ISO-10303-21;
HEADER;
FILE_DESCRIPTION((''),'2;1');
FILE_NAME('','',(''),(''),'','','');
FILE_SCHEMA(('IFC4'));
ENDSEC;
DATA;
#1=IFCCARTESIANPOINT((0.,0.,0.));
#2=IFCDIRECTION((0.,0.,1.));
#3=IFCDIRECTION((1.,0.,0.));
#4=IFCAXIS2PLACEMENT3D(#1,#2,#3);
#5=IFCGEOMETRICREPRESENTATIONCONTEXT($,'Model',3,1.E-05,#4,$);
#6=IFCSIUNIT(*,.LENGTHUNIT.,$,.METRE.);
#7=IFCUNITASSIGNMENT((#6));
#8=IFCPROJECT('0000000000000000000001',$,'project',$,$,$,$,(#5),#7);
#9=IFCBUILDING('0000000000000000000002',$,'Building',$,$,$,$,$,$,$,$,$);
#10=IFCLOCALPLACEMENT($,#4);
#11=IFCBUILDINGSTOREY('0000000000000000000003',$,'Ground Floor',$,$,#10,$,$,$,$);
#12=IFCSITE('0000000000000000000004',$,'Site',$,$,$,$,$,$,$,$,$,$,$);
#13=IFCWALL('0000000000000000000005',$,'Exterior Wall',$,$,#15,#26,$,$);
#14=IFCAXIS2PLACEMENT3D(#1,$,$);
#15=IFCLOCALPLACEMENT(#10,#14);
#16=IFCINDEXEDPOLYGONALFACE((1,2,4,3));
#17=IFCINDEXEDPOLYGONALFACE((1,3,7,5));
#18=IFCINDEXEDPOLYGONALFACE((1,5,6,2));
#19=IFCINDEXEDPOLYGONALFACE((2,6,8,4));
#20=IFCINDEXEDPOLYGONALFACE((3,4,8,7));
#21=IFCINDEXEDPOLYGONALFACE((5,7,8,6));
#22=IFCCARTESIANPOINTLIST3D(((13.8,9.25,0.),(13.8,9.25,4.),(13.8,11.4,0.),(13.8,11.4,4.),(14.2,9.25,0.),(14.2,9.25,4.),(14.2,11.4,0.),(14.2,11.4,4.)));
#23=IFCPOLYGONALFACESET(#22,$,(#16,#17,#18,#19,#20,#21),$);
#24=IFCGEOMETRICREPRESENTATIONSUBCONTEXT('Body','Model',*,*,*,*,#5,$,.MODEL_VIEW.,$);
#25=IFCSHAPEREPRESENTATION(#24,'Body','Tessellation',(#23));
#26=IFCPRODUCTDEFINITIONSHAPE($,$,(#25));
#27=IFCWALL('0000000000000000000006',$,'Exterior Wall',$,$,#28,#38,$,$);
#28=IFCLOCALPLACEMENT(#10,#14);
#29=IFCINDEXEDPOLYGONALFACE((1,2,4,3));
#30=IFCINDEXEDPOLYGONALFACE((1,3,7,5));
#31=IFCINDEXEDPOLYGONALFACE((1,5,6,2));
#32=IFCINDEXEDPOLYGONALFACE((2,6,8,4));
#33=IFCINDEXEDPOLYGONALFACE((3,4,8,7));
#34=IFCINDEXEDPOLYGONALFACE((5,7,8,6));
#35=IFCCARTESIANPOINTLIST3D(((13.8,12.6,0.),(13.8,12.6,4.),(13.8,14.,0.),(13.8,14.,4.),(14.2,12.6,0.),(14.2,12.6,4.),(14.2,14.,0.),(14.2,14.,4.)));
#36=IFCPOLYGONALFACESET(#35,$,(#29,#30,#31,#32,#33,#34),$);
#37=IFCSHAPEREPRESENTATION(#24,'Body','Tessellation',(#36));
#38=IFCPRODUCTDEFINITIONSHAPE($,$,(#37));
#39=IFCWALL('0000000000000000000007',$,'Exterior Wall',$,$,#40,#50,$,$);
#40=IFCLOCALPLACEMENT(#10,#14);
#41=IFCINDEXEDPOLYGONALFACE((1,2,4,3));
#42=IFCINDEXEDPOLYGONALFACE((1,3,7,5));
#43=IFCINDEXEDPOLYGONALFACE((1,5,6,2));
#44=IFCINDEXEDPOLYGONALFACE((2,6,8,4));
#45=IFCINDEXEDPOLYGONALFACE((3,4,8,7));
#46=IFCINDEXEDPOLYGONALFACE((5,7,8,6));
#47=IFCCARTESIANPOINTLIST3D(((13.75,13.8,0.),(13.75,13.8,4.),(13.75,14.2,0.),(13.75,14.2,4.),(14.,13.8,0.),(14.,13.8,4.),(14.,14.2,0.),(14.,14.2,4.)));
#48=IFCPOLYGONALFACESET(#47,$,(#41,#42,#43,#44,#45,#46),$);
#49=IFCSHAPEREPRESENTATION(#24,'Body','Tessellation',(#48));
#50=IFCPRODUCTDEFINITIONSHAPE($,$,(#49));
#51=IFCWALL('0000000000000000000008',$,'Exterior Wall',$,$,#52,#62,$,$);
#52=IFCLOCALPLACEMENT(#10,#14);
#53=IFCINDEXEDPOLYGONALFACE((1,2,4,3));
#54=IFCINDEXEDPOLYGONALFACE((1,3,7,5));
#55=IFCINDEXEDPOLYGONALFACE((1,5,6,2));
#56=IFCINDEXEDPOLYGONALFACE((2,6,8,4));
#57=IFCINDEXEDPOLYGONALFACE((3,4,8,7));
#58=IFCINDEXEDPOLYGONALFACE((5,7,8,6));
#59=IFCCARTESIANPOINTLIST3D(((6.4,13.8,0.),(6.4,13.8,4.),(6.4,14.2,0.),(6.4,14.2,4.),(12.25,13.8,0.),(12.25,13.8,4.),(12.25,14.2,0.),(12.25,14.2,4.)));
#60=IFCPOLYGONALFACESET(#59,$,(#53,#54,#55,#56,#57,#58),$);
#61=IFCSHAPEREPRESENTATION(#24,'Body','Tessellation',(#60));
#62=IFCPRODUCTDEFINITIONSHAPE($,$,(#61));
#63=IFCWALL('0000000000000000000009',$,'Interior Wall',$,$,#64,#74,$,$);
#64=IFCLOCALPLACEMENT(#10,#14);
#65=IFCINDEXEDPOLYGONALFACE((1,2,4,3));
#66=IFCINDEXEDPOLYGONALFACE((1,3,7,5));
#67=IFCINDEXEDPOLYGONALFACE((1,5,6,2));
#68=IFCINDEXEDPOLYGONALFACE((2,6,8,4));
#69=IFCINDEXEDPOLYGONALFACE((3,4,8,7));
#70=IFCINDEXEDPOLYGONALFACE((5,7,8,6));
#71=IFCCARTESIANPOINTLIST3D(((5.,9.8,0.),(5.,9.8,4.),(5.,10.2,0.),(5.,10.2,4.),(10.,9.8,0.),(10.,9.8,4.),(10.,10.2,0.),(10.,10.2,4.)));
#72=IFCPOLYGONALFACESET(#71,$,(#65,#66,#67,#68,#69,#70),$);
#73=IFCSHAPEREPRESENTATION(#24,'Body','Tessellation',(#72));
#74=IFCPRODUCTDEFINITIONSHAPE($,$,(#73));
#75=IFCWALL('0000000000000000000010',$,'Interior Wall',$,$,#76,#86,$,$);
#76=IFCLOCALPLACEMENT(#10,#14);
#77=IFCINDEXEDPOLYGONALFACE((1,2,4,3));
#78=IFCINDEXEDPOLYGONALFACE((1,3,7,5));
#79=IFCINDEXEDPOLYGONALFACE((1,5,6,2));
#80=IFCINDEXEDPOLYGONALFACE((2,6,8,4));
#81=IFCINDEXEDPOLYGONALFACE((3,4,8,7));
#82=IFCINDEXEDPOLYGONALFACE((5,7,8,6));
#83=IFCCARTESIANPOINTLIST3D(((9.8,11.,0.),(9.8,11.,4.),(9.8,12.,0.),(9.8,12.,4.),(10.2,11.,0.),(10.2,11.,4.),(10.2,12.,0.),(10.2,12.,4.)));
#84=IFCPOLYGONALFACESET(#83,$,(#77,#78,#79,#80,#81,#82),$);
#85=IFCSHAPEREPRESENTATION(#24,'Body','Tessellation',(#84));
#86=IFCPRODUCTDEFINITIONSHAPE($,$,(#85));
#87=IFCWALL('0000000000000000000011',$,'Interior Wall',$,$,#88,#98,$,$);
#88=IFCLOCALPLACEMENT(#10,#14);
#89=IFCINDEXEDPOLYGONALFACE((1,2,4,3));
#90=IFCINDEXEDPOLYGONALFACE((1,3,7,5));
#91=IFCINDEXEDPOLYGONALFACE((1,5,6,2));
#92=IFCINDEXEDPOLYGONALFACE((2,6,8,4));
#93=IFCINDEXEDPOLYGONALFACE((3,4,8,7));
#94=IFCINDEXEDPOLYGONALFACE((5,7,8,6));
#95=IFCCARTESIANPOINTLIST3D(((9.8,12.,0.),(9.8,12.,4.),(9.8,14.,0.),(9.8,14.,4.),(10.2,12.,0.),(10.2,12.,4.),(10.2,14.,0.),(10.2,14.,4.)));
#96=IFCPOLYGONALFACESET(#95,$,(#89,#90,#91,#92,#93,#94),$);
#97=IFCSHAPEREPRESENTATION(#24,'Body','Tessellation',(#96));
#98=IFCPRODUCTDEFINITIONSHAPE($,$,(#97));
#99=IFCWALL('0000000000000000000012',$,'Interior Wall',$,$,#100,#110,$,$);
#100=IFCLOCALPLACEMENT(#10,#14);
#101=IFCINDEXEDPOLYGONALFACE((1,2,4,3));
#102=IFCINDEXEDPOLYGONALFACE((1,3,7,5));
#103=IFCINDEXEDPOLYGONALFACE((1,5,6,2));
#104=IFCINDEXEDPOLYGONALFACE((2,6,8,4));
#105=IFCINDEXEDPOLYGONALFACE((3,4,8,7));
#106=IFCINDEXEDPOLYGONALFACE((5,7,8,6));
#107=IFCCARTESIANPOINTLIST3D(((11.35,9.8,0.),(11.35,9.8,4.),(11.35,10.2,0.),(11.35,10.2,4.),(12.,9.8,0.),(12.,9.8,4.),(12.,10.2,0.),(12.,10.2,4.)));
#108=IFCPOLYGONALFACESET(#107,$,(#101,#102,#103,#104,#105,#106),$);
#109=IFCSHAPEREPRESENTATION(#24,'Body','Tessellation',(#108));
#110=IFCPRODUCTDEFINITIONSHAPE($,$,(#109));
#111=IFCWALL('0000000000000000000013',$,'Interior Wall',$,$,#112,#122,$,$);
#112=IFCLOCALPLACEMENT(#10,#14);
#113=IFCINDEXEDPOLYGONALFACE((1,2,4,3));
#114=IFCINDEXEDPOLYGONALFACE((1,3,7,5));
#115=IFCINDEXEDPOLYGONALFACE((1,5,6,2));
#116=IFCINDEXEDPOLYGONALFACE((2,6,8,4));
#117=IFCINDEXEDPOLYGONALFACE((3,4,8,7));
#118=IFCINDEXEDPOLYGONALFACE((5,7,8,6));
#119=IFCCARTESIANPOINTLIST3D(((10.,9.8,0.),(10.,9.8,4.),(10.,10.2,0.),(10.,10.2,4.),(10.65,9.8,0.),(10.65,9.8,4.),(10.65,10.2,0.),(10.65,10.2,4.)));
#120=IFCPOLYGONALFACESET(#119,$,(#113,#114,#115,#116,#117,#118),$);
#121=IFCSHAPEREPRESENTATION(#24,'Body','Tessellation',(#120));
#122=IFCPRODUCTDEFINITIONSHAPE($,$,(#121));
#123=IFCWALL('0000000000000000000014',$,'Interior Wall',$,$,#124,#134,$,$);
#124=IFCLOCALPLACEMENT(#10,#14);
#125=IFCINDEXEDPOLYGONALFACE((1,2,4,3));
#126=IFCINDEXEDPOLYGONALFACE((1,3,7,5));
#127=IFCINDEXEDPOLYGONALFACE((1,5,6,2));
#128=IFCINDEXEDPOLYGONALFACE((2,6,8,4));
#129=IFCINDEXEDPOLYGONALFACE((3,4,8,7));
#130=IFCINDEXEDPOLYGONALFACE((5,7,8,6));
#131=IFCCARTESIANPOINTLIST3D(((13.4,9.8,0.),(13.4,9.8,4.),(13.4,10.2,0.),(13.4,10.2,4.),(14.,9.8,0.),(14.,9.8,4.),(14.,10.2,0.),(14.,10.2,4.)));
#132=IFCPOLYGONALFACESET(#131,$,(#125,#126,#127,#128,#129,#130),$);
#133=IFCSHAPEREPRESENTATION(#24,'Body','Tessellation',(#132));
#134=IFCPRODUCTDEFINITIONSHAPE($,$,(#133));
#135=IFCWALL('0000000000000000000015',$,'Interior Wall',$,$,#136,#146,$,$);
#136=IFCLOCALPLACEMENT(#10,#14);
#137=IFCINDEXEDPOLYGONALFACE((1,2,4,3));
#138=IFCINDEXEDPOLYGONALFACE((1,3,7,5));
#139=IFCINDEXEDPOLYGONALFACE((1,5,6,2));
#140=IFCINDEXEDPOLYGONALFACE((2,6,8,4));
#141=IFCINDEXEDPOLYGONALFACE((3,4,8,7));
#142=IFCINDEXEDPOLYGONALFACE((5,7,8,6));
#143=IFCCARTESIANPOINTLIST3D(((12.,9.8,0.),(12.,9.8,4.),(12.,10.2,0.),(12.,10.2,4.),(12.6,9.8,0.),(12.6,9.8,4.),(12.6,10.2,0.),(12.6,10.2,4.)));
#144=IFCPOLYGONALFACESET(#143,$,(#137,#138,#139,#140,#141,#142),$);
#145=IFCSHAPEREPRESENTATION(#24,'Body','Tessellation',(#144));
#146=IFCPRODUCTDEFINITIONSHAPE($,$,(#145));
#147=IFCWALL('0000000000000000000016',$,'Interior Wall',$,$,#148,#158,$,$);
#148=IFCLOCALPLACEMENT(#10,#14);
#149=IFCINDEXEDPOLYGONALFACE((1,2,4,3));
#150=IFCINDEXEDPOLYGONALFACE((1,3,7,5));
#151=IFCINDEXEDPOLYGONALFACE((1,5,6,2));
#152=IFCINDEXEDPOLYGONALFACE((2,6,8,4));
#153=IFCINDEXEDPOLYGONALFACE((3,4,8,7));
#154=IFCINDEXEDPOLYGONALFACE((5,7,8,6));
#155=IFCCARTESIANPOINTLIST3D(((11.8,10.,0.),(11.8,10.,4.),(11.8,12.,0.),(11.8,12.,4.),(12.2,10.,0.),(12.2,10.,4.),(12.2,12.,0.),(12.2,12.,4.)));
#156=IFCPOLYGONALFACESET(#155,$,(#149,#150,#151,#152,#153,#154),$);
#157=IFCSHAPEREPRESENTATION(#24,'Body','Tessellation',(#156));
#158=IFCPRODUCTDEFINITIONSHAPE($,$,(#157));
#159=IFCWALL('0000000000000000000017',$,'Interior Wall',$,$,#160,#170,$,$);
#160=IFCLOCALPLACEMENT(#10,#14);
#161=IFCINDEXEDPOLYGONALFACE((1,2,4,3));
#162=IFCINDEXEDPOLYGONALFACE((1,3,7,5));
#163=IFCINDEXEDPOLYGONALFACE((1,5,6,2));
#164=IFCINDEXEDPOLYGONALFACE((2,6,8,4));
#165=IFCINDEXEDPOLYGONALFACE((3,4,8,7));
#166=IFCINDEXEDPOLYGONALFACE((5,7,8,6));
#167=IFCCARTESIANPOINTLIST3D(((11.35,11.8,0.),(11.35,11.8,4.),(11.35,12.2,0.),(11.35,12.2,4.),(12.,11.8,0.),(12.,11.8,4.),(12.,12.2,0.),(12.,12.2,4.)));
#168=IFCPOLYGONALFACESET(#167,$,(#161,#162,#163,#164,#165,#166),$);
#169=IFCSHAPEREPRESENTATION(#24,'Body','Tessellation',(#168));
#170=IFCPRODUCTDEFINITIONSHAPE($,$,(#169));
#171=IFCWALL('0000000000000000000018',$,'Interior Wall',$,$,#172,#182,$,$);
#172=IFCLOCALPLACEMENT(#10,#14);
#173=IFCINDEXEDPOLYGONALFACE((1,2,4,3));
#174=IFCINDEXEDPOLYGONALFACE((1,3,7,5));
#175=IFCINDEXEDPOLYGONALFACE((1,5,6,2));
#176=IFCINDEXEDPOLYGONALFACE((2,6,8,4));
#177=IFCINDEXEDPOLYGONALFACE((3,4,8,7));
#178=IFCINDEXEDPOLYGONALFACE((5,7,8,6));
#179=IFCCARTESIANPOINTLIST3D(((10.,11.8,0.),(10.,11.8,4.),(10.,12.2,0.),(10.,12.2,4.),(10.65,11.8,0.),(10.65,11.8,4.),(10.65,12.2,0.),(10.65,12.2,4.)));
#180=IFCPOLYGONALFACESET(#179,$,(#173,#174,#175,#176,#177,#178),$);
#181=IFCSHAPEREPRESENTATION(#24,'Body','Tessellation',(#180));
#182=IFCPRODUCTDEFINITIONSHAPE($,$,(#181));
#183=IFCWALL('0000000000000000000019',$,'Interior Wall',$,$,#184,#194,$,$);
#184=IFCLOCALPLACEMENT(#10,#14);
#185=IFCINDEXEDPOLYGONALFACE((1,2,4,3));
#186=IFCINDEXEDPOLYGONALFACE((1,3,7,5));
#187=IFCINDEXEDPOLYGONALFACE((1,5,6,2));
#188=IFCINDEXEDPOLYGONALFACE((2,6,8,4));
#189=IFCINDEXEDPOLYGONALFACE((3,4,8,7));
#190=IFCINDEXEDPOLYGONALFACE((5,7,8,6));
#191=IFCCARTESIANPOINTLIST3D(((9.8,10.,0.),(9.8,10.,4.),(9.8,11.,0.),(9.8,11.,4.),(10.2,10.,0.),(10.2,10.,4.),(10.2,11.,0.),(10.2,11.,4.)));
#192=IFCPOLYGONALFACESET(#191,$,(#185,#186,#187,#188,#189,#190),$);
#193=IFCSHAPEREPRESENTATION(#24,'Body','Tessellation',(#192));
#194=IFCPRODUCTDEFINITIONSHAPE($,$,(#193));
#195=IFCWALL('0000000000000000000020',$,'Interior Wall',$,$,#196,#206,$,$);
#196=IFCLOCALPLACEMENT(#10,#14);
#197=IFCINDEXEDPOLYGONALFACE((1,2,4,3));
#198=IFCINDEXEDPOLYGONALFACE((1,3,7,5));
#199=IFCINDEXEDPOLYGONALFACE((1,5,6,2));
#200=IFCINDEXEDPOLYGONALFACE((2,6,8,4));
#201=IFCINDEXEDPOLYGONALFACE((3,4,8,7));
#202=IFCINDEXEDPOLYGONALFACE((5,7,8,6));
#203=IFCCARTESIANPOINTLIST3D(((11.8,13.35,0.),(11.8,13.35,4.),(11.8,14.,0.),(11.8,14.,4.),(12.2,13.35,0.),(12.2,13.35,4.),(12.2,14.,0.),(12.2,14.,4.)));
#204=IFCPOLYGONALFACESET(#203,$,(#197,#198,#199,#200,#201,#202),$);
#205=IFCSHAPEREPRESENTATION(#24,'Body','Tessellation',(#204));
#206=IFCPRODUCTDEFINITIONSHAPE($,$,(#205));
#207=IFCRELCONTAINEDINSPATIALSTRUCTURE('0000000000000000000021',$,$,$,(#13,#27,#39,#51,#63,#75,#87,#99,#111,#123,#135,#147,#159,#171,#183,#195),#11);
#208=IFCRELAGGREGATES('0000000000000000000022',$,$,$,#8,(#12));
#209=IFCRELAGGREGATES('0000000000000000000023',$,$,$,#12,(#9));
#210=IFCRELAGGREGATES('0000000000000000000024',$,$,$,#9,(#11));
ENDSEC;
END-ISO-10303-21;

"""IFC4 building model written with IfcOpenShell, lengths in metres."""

from ifc_helpers import new_model, si_unit, frame, origin_with_axes, place, context, subcontext, project, spatial, indexed_curve, outline, extrude, element, save


model = new_model("IFC4")

# Units and contexts
model_context = context("Model", 3, precision=1e-05, world=origin_with_axes())
body_context = subcontext(model_context, "Body", "Model", "MODEL_VIEW")
ifc_project = project(units=[si_unit("LENGTHUNIT", "METRE")], contexts=[model_context])

# Site, building, storey
site = spatial("IfcSite", under=ifc_project, Name="Site")
building = spatial("IfcBuilding", under=site, Name="Building")
storey_placement = place(None, origin_with_axes())
storey = spatial("IfcBuildingStorey", under=building, at=storey_placement, Name="Ground Floor")

# Walls
wall_1_placement = place(storey_placement, frame((14.0, 9.25, 0.0), z_axis=(0.0, 0.0, 1.0), x_axis=(0.0, 1.0, 0.0)))
element("IfcWall", 1, at=wall_1_placement, inside=storey, Name="Exterior Wall", context=body_context, shape_type="SweptSolid", body=[
    extrude(outline(indexed_curve([(0.0, 0.0), (0.0, 0.4), (2.15, 0.4), (2.15, 0.0), (0.0, 0.0)], self_intersect=False)), frame((0.0, -0.2, 0.0), z_axis=(0.0, 0.0, 1.0), x_axis=(1.0, 0.0, 0.0)), (0.0, 0.0, 1.0), 4.0),
])
wall_2_placement = place(storey_placement, frame((14.0, 12.6, 0.0), z_axis=(0.0, 0.0, 1.0), x_axis=(0.0, 1.0, 0.0)))
element("IfcWall", 2, at=wall_2_placement, inside=storey, Name="Exterior Wall", context=body_context, shape_type="SweptSolid", body=[
    extrude(outline(indexed_curve([(0.0, 0.0), (0.0, 0.4), (1.4, 0.4), (1.4, 0.0), (0.0, 0.0)], self_intersect=False)), frame((0.0, -0.2, 0.0), z_axis=(0.0, 0.0, 1.0), x_axis=(1.0, 0.0, 0.0)), (0.0, 0.0, 1.0), 4.0),
])
wall_3_placement = place(storey_placement, frame((14.0, 14.0, 0.0), z_axis=(0.0, 0.0, 1.0), x_axis=(-1.0, 0.0, 0.0)))
element("IfcWall", 3, at=wall_3_placement, inside=storey, Name="Exterior Wall", context=body_context, shape_type="SweptSolid", body=[
    extrude(outline(indexed_curve([(0.0, 0.0), (0.0, 0.4), (0.25, 0.4), (0.25, 0.0), (0.0, 0.0)], self_intersect=False)), frame((0.0, -0.2, 0.0), z_axis=(0.0, 0.0, 1.0), x_axis=(1.0, 0.0, 0.0)), (0.0, 0.0, 1.0), 4.0),
])
wall_4_placement = place(storey_placement, frame((12.25, 14.0, 0.0), z_axis=(0.0, 0.0, 1.0), x_axis=(-1.0, 0.0, 0.0)))
element("IfcWall", 4, at=wall_4_placement, inside=storey, Name="Exterior Wall", context=body_context, shape_type="SweptSolid", body=[
    extrude(outline(indexed_curve([(0.0, 0.0), (0.0, 0.4), (5.85, 0.4), (5.85, 0.0), (0.0, 0.0)], self_intersect=False)), frame((0.0, -0.2, 0.0), z_axis=(0.0, 0.0, 1.0), x_axis=(1.0, 0.0, 0.0)), (0.0, 0.0, 1.0), 4.0),
])
wall_5_placement = place(storey_placement, frame((10.0, 10.0, 0.0), z_axis=(0.0, 0.0, 1.0), x_axis=(-1.0, 0.0, 0.0)))
element("IfcWall", 5, at=wall_5_placement, inside=storey, Name="Interior Wall", context=body_context, shape_type="SweptSolid", body=[
    extrude(outline(indexed_curve([(0.0, 0.0), (0.0, 0.4), (5.0, 0.4), (5.0, 0.0), (0.0, 0.0)], self_intersect=False)), frame((0.0, -0.2, 0.0), z_axis=(0.0, 0.0, 1.0), x_axis=(1.0, 0.0, 0.0)), (0.0, 0.0, 1.0), 4.0),
])
wall_6_placement = place(storey_placement, frame((10.0, 11.0, 0.0), z_axis=(0.0, 0.0, 1.0), x_axis=(0.0, 1.0, 0.0)))
element("IfcWall", 6, at=wall_6_placement, inside=storey, Name="Interior Wall", context=body_context, shape_type="SweptSolid", body=[
    extrude(outline(indexed_curve([(0.0, 0.0), (0.0, 0.4), (1.0, 0.4), (1.0, 0.0), (0.0, 0.0)], self_intersect=False)), frame((0.0, -0.2, 0.0), z_axis=(0.0, 0.0, 1.0), x_axis=(1.0, 0.0, 0.0)), (0.0, 0.0, 1.0), 4.0),
])
wall_7_placement = place(storey_placement, frame((10.0, 12.0, 0.0), z_axis=(0.0, 0.0, 1.0), x_axis=(0.0, 1.0, 0.0)))
element("IfcWall", 7, at=wall_7_placement, inside=storey, Name="Interior Wall", context=body_context, shape_type="SweptSolid", body=[
    extrude(outline(indexed_curve([(0.0, 0.0), (0.0, 0.4), (2.0, 0.4), (2.0, 0.0), (0.0, 0.0)], self_intersect=False)), frame((0.0, -0.2, 0.0), z_axis=(0.0, 0.0, 1.0), x_axis=(1.0, 0.0, 0.0)), (0.0, 0.0, 1.0), 4.0),
])
for number, where, z_axis, x_axis, name in (
    (8, (12.0, 10.0, 0.0), (0.0, 0.0, 1.0), (-1.0, 0.0, 0.0), "Interior Wall"),
    (9, (10.65, 10.0, 0.0), (0.0, 0.0, 1.0), (-1.0, 0.0, 0.0), "Interior Wall"),
):
    element("IfcWall", number, at=place(storey_placement, frame(where, z_axis=z_axis, x_axis=x_axis)), inside=storey, Name=name, context=body_context, shape_type="SweptSolid", body=[
        extrude(outline(indexed_curve([(0.0, 0.0), (0.0, 0.4), (0.65, 0.4), (0.65, 0.0), (0.0, 0.0)], self_intersect=False)), frame((0.0, -0.2, 0.0), z_axis=(0.0, 0.0, 1.0), x_axis=(1.0, 0.0, 0.0)), (0.0, 0.0, 1.0), 4.0),
    ])
for number, where, z_axis, x_axis, name in (
    (10, (14.0, 10.0, 0.0), (0.0, 0.0, 1.0), (-1.0, 0.0, 0.0), "Interior Wall"),
    (11, (12.6, 10.0, 0.0), (0.0, 0.0, 1.0), (-1.0, 0.0, 0.0), "Interior Wall"),
):
    element("IfcWall", number, at=place(storey_placement, frame(where, z_axis=z_axis, x_axis=x_axis)), inside=storey, Name=name, context=body_context, shape_type="SweptSolid", body=[
        extrude(outline(indexed_curve([(0.0, 0.0), (0.0, 0.4), (0.6, 0.4), (0.6, 0.0), (0.0, 0.0)], self_intersect=False)), frame((0.0, -0.2, 0.0), z_axis=(0.0, 0.0, 1.0), x_axis=(1.0, 0.0, 0.0)), (0.0, 0.0, 1.0), 4.0),
    ])
wall_8_placement = place(storey_placement, frame((12.0, 10.0, 0.0), z_axis=(0.0, 0.0, 1.0), x_axis=(0.0, 1.0, 0.0)))
element("IfcWall", 12, at=wall_8_placement, inside=storey, Name="Interior Wall", context=body_context, shape_type="SweptSolid", body=[
    extrude(outline(indexed_curve([(0.0, 0.0), (0.0, 0.4), (2.0, 0.4), (2.0, 0.0), (0.0, 0.0)], self_intersect=False)), frame((0.0, -0.2, 0.0), z_axis=(0.0, 0.0, 1.0), x_axis=(1.0, 0.0, 0.0)), (0.0, 0.0, 1.0), 4.0),
])
for number, where, z_axis, x_axis, name in (
    (13, (12.0, 12.0, 0.0), (0.0, 0.0, 1.0), (-1.0, 0.0, 0.0), "Interior Wall"),
    (14, (10.65, 12.0, 0.0), (0.0, 0.0, 1.0), (-1.0, 0.0, 0.0), "Interior Wall"),
):
    element("IfcWall", number, at=place(storey_placement, frame(where, z_axis=z_axis, x_axis=x_axis)), inside=storey, Name=name, context=body_context, shape_type="SweptSolid", body=[
        extrude(outline(indexed_curve([(0.0, 0.0), (0.0, 0.4), (0.65, 0.4), (0.65, 0.0), (0.0, 0.0)], self_intersect=False)), frame((0.0, -0.2, 0.0), z_axis=(0.0, 0.0, 1.0), x_axis=(1.0, 0.0, 0.0)), (0.0, 0.0, 1.0), 4.0),
    ])
wall_9_placement = place(storey_placement, frame((10.0, 11.0, 0.0), z_axis=(0.0, 0.0, 1.0), x_axis=(0.0, -1.0, 0.0)))
element("IfcWall", 15, at=wall_9_placement, inside=storey, Name="Interior Wall", context=body_context, shape_type="SweptSolid", body=[
    extrude(outline(indexed_curve([(0.0, 0.0), (0.0, 0.4), (1.0, 0.4), (1.0, 0.0), (0.0, 0.0)], self_intersect=False)), frame((0.0, -0.2, 0.0), z_axis=(0.0, 0.0, 1.0), x_axis=(1.0, 0.0, 0.0)), (0.0, 0.0, 1.0), 4.0),
])
for number, where, z_axis, x_axis, name in (
    (16, (12.0, 14.0, 0.0), (0.0, 0.0, 1.0), (0.0, -1.0, 0.0), "Interior Wall"),
):
    element("IfcWall", number, at=place(storey_placement, frame(where, z_axis=z_axis, x_axis=x_axis)), inside=storey, Name=name, context=body_context, shape_type="SweptSolid", body=[
        extrude(outline(indexed_curve([(0.0, 0.0), (0.0, 0.4), (0.65, 0.4), (0.65, 0.0), (0.0, 0.0)], self_intersect=False)), frame((0.0, -0.2, 0.0), z_axis=(0.0, 0.0, 1.0), x_axis=(1.0, 0.0, 0.0)), (0.0, 0.0, 1.0), 4.0),
    ])

save(model, "model.ifc")
